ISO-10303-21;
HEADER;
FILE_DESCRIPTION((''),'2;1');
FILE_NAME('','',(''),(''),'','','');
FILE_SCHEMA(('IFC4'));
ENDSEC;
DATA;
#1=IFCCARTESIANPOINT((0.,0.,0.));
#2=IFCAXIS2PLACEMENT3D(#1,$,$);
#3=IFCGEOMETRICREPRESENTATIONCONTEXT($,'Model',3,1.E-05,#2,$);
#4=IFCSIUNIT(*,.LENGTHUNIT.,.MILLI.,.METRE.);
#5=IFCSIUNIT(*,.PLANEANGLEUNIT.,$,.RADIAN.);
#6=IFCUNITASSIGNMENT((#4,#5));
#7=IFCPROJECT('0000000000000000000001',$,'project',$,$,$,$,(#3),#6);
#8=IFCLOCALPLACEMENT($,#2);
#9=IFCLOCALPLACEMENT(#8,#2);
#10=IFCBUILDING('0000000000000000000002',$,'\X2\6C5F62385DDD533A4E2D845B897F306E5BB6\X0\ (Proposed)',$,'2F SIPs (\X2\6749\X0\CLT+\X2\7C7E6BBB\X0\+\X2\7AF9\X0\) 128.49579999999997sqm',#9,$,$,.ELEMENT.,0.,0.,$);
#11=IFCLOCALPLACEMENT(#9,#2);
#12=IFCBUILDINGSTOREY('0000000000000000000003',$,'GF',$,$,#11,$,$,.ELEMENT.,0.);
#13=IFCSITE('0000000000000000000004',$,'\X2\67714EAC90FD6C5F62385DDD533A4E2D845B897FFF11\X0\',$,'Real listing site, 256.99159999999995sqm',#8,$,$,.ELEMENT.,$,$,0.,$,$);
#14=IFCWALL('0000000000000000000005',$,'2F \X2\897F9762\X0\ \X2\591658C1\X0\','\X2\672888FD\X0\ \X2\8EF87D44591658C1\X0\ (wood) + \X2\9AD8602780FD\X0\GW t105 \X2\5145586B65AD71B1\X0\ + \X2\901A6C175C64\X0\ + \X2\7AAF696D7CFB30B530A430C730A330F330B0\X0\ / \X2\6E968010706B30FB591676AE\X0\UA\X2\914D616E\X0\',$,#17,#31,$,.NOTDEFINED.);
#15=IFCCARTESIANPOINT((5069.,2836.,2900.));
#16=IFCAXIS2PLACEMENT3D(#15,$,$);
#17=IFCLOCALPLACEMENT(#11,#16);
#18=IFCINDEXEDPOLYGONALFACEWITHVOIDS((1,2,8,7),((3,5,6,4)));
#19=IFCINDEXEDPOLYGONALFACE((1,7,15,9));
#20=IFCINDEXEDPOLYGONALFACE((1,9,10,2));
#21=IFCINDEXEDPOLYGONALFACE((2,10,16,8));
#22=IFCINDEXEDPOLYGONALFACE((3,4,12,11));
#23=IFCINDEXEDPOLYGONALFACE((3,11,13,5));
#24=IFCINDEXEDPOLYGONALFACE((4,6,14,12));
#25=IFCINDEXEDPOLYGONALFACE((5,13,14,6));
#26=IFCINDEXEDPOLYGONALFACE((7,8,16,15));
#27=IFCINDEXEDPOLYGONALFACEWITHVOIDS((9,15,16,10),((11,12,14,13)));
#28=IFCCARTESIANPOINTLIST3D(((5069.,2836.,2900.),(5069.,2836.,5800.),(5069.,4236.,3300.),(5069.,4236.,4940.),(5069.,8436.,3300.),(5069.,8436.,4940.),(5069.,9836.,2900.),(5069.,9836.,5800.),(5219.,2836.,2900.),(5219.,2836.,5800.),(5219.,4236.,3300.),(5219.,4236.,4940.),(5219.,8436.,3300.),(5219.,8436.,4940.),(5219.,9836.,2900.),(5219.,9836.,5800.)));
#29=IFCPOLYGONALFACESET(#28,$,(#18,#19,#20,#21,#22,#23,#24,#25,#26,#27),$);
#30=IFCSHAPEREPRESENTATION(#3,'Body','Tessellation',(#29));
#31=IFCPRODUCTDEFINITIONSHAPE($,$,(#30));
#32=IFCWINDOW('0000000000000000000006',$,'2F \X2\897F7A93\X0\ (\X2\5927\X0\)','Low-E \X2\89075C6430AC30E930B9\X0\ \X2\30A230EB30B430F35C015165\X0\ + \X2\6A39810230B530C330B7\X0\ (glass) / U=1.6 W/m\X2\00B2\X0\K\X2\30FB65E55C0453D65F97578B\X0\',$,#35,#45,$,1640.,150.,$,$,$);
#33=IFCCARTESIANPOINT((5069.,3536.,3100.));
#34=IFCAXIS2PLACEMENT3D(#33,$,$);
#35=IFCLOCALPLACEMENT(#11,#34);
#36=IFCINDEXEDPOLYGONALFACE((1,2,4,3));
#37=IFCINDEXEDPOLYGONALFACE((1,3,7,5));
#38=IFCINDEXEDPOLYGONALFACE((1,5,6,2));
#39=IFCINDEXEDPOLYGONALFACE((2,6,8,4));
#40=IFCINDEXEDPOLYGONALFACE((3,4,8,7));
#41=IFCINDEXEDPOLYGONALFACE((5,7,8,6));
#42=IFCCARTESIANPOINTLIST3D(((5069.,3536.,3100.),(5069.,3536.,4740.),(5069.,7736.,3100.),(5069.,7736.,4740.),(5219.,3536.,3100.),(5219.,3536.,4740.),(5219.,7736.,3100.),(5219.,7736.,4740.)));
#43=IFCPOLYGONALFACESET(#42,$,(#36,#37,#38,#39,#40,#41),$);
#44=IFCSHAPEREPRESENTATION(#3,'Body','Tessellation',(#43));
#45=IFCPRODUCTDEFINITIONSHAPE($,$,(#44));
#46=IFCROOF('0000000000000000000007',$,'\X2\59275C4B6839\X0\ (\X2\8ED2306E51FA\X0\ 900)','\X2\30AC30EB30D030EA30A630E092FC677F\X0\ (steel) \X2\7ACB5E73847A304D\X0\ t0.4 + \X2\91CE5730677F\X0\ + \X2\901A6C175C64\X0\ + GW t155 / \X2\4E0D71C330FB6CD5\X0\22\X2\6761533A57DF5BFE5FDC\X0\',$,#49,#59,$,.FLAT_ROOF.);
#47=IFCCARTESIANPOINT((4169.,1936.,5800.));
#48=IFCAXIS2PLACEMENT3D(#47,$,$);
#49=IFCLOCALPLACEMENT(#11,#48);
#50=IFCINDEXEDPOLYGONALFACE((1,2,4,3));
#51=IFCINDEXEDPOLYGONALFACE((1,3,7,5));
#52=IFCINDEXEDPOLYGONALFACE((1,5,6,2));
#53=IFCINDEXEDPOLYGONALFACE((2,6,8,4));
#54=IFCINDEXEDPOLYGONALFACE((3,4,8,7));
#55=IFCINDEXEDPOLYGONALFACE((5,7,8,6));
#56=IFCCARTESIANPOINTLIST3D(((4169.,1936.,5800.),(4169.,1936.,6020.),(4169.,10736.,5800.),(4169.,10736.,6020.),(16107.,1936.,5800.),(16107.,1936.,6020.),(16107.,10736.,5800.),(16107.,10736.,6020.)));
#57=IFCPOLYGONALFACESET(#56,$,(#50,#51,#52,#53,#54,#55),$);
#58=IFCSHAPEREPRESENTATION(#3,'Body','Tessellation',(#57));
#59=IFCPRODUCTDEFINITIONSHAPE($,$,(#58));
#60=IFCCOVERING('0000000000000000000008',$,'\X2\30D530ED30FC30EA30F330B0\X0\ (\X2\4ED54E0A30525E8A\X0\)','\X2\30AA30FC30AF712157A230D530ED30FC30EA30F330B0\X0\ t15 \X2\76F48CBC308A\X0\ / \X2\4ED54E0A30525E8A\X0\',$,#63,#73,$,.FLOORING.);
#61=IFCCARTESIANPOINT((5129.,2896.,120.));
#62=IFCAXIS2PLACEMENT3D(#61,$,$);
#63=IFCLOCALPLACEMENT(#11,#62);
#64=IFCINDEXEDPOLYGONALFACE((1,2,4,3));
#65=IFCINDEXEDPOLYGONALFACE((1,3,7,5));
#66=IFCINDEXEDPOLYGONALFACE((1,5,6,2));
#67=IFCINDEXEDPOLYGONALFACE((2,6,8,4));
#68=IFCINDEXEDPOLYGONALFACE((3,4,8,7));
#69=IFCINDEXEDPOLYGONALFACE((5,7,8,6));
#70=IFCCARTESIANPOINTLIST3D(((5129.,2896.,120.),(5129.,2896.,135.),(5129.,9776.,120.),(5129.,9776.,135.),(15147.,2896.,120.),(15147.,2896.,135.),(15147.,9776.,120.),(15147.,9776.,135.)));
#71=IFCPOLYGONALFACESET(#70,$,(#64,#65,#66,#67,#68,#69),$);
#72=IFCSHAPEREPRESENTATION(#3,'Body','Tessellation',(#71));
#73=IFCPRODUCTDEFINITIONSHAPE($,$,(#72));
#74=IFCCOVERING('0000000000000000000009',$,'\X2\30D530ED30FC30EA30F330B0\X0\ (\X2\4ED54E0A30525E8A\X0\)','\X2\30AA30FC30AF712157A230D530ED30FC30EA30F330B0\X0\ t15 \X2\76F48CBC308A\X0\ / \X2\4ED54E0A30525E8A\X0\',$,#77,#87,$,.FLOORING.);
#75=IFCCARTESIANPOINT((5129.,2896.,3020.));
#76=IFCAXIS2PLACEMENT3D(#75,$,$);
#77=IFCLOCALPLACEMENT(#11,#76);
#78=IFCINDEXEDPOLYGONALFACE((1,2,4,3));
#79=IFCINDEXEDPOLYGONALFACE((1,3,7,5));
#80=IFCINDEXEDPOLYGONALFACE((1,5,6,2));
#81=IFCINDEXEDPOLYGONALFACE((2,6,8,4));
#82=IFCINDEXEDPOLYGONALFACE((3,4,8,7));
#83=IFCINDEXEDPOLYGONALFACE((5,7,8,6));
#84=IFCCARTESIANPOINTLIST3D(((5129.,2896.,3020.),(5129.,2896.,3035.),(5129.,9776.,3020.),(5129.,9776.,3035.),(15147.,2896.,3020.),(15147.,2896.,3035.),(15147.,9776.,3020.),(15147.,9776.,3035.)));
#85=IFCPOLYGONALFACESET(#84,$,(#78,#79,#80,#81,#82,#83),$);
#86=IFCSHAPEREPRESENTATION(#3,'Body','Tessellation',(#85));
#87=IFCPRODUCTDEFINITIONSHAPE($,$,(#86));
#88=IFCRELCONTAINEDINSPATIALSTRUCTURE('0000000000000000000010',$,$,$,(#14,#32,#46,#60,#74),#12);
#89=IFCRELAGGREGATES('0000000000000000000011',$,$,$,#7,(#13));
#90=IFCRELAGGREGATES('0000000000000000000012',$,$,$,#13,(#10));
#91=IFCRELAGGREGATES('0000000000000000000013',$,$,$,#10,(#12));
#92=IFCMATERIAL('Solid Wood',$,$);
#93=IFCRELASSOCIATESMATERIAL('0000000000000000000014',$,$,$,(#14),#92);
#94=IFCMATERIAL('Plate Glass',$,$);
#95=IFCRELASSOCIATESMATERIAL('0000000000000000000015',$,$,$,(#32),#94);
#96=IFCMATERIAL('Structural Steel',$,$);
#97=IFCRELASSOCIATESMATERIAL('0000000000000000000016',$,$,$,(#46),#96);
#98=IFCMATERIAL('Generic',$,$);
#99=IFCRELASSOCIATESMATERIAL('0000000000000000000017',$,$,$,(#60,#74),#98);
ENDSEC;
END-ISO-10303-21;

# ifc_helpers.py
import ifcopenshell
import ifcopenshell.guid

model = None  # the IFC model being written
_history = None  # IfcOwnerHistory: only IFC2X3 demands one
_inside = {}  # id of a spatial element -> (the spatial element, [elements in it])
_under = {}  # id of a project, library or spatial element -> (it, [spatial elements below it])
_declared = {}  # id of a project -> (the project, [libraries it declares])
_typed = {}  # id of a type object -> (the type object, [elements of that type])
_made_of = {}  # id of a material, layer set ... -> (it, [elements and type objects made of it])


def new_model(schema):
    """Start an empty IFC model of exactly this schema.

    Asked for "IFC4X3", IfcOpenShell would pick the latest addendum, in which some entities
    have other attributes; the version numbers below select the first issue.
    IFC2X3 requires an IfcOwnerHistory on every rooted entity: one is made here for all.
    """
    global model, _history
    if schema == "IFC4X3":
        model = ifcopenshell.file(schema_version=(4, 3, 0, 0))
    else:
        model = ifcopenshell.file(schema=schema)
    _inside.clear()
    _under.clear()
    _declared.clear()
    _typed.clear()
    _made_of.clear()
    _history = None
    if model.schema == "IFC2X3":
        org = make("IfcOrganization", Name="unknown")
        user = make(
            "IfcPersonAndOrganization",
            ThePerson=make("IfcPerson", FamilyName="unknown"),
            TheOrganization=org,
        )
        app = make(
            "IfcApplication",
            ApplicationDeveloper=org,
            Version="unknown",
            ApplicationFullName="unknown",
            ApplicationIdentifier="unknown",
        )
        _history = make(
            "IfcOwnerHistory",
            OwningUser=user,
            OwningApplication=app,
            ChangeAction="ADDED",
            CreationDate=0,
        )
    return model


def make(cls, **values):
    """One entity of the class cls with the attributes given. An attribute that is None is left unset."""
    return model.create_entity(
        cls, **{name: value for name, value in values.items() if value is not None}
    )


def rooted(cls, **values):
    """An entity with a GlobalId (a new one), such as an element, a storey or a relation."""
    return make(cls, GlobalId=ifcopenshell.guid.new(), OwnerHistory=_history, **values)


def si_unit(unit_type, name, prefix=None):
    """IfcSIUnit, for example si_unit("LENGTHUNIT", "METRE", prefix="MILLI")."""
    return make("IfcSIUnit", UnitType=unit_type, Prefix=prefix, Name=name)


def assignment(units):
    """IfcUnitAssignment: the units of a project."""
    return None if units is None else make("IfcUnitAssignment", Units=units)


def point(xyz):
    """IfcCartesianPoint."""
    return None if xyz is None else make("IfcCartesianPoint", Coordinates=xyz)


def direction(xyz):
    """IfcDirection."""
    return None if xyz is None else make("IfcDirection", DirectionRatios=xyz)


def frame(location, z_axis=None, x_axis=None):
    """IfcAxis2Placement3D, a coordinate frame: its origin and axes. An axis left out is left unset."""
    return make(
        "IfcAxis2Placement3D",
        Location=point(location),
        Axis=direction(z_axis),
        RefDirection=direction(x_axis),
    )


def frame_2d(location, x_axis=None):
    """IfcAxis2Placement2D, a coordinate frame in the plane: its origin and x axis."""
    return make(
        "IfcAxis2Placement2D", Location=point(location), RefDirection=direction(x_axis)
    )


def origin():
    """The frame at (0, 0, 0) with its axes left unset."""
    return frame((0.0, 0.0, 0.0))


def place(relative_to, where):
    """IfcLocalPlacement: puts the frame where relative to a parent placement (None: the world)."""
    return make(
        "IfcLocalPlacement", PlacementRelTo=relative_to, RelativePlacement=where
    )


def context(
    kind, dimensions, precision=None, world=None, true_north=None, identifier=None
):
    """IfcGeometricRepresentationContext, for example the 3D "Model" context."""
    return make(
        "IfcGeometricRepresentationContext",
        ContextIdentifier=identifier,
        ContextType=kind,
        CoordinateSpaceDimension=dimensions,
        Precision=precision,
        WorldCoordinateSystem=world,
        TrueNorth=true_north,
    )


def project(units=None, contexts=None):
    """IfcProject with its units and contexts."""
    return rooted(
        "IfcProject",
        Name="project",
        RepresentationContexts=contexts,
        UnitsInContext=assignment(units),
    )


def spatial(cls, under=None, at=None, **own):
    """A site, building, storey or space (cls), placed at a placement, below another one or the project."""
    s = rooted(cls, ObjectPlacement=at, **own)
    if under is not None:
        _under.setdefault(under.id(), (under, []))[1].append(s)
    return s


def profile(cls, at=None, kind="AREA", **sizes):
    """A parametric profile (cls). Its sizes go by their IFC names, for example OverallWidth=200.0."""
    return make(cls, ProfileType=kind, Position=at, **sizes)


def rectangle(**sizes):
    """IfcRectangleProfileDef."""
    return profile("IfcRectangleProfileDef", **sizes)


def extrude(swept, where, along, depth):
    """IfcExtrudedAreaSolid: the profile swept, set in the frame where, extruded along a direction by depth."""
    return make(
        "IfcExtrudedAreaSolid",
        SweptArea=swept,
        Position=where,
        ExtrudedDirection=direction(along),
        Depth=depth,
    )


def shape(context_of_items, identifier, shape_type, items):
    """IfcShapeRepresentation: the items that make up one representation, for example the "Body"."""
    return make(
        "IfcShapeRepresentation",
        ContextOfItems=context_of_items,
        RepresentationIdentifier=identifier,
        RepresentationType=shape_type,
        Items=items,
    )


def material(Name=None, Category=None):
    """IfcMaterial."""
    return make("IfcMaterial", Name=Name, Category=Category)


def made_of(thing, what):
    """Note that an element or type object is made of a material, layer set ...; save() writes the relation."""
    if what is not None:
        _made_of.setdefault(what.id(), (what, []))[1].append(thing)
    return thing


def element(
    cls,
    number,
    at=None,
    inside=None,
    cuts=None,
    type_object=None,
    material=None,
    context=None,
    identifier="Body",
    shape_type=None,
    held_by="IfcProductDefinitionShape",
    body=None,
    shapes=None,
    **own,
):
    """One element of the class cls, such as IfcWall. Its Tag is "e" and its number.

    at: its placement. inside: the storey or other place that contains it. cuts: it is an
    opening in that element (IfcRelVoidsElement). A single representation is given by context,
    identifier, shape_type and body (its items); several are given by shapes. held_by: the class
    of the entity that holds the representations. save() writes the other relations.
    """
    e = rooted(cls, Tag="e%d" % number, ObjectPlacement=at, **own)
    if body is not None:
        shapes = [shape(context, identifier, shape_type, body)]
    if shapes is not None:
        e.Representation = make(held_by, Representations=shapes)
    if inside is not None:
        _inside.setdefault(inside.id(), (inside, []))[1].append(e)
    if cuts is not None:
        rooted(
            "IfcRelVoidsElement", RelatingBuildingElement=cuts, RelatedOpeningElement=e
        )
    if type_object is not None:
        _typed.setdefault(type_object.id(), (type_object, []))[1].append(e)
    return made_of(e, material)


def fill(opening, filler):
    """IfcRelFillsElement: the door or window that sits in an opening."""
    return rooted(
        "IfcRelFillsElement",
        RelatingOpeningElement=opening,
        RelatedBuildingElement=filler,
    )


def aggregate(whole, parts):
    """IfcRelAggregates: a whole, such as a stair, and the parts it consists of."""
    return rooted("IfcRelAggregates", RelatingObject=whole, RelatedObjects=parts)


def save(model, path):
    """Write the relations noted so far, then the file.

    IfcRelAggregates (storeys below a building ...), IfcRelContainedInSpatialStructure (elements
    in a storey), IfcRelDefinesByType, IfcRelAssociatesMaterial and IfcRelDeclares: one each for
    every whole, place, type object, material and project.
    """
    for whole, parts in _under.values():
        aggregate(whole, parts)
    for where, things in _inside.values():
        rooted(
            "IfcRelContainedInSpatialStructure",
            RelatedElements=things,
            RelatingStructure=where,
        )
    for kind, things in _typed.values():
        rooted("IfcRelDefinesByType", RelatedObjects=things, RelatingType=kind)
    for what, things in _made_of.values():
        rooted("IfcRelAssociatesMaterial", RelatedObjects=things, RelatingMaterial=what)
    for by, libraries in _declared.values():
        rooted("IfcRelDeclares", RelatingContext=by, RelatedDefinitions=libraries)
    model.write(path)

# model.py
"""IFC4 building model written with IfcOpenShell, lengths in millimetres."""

from ifc_helpers import new_model, si_unit, frame, frame_2d, origin, place, context, project, spatial, rectangle, extrude, material, element, fill, save


model = new_model("IFC4")

# Units and contexts
model_context = context("Model", 3, precision=1e-05, world=origin())
ifc_project = project(units=[si_unit("LENGTHUNIT", "METRE", prefix="MILLI"), si_unit("PLANEANGLEUNIT", "RADIAN")], contexts=[model_context])

# Site, building, storey
site_placement = place(None, origin())
site = spatial("IfcSite", under=ifc_project, at=site_placement, Name="東京都江戸川区中葛西１", ObjectType="Real listing site, 256.99159999999995sqm", CompositionType="ELEMENT", RefElevation=0.0)
building_placement = place(site_placement, origin())
building = spatial("IfcBuilding", under=site, at=building_placement, Name="江戸川区中葛西の家 (Proposed)", ObjectType="2F SIPs (杉CLT+籾殻+竹) 128.49579999999997sqm", CompositionType="ELEMENT", ElevationOfRefHeight=0.0, ElevationOfTerrain=0.0)
storey_placement = place(building_placement, origin())
storey = spatial("IfcBuildingStorey", under=building, at=storey_placement, Name="GF", CompositionType="ELEMENT", Elevation=0.0)

# Shared definitions
ifc_material_1 = material(Name="Solid Wood")

# Shared definitions
ifc_material_2 = material(Name="Plate Glass")

# Wall, opening, window
wall_1_placement = place(storey_placement, frame((5069.0, 2836.0, 2900.0)))
wall_1 = element("IfcWall", 1, at=wall_1_placement, inside=storey, material=ifc_material_1, Name="2F 西面 外壁", Description="木製 軸組外壁 (wood) + 高性能GW t105 充填断熱 + 通気層 + 窯業系サイディング / 準耐火・外皮UA配慮", PredefinedType="NOTDEFINED", context=model_context, shape_type="SweptSolid", body=[
    extrude(rectangle(XDim=150.0, YDim=7000.0, at=frame_2d((75.0, 3500.0))), frame((5069.0, 2836.0, 2900.0)), (0.0, 0.0, 1.0), 2900.0),
])
opening_1_placement = place(storey_placement, frame((5069.0, 3536.0, 3100.0)))
opening_1 = element("IfcOpeningElement", 2, at=opening_1_placement, cuts=wall_1, PredefinedType="NOTDEFINED", context=model_context, shape_type="SweptSolid", body=[
    extrude(rectangle(XDim=150.0, YDim=4200.0, at=frame_2d((75.0, 2100.0))), frame((5069.0, 3536.0, 3100.0)), (0.0, 0.0, 1.0), 1640.0),
])
window_1_placement = place(storey_placement, frame((5069.0, 3536.0, 3100.0)))
window_1 = element("IfcWindow", 3, at=window_1_placement, inside=storey, material=ifc_material_2, Name="2F 西窓 (大)", Description="Low-E 複層ガラス アルゴン封入 + 樹脂サッシ (glass) / U=1.6 W/m²K・日射取得型", OverallHeight=1640.0, OverallWidth=150.0, context=model_context, shape_type="SweptSolid", body=[
    extrude(rectangle(XDim=150.0, YDim=4200.0, at=frame_2d((75.0, 2100.0))), frame((5069.0, 3536.0, 3100.0)), (0.0, 0.0, 1.0), 1640.0),
])
fill(opening_1, window_1)

# Roof
ifc_material_3 = material(Name="Structural Steel")
roof_placement = place(storey_placement, frame((4169.0, 1936.0, 5800.0)))
element("IfcRoof", 4, at=roof_placement, inside=storey, material=ifc_material_3, Name="大屋根 (軒の出 900)", Description="ガルバリウム鋼板 (steel) 立平葺き t0.4 + 野地板 + 通気層 + GW t155 / 不燃・法22条区域対応", PredefinedType="FLAT_ROOF", context=model_context, shape_type="SweptSolid", body=[
    extrude(rectangle(XDim=11938.0, YDim=8800.0, at=frame_2d((5969.0, 4400.0))), frame((4169.0, 1936.0, 5800.0)), (0.0, 0.0, 1.0), 220.0),
])

# Coverings
ifc_material_4 = material(Name="Generic")
covering_1_placement = place(storey_placement, frame((5129.0, 2896.0, 120.0)))
element("IfcCovering", 5, at=covering_1_placement, inside=storey, material=ifc_material_4, Name="フローリング (仕上げ床)", Description="オーク無垢フローリング t15 直貼り / 仕上げ床", PredefinedType="FLOORING", context=model_context, shape_type="SweptSolid", body=[
    extrude(rectangle(XDim=10018.0, YDim=6880.0, at=frame_2d((5009.0, 3440.0))), frame((5129.0, 2896.0, 120.0)), (0.0, 0.0, 1.0), 15.0),
])
covering_2_placement = place(storey_placement, frame((5129.0, 2896.0, 3020.0)))
element("IfcCovering", 6, at=covering_2_placement, inside=storey, material=ifc_material_4, Name="フローリング (仕上げ床)", Description="オーク無垢フローリング t15 直貼り / 仕上げ床", PredefinedType="FLOORING", context=model_context, shape_type="SweptSolid", body=[
    extrude(rectangle(XDim=10018.0, YDim=6880.0, at=frame_2d((5009.0, 3440.0))), frame((5129.0, 2896.0, 3020.0)), (0.0, 0.0, 1.0), 15.0),
])

save(model, "model.ifc")
